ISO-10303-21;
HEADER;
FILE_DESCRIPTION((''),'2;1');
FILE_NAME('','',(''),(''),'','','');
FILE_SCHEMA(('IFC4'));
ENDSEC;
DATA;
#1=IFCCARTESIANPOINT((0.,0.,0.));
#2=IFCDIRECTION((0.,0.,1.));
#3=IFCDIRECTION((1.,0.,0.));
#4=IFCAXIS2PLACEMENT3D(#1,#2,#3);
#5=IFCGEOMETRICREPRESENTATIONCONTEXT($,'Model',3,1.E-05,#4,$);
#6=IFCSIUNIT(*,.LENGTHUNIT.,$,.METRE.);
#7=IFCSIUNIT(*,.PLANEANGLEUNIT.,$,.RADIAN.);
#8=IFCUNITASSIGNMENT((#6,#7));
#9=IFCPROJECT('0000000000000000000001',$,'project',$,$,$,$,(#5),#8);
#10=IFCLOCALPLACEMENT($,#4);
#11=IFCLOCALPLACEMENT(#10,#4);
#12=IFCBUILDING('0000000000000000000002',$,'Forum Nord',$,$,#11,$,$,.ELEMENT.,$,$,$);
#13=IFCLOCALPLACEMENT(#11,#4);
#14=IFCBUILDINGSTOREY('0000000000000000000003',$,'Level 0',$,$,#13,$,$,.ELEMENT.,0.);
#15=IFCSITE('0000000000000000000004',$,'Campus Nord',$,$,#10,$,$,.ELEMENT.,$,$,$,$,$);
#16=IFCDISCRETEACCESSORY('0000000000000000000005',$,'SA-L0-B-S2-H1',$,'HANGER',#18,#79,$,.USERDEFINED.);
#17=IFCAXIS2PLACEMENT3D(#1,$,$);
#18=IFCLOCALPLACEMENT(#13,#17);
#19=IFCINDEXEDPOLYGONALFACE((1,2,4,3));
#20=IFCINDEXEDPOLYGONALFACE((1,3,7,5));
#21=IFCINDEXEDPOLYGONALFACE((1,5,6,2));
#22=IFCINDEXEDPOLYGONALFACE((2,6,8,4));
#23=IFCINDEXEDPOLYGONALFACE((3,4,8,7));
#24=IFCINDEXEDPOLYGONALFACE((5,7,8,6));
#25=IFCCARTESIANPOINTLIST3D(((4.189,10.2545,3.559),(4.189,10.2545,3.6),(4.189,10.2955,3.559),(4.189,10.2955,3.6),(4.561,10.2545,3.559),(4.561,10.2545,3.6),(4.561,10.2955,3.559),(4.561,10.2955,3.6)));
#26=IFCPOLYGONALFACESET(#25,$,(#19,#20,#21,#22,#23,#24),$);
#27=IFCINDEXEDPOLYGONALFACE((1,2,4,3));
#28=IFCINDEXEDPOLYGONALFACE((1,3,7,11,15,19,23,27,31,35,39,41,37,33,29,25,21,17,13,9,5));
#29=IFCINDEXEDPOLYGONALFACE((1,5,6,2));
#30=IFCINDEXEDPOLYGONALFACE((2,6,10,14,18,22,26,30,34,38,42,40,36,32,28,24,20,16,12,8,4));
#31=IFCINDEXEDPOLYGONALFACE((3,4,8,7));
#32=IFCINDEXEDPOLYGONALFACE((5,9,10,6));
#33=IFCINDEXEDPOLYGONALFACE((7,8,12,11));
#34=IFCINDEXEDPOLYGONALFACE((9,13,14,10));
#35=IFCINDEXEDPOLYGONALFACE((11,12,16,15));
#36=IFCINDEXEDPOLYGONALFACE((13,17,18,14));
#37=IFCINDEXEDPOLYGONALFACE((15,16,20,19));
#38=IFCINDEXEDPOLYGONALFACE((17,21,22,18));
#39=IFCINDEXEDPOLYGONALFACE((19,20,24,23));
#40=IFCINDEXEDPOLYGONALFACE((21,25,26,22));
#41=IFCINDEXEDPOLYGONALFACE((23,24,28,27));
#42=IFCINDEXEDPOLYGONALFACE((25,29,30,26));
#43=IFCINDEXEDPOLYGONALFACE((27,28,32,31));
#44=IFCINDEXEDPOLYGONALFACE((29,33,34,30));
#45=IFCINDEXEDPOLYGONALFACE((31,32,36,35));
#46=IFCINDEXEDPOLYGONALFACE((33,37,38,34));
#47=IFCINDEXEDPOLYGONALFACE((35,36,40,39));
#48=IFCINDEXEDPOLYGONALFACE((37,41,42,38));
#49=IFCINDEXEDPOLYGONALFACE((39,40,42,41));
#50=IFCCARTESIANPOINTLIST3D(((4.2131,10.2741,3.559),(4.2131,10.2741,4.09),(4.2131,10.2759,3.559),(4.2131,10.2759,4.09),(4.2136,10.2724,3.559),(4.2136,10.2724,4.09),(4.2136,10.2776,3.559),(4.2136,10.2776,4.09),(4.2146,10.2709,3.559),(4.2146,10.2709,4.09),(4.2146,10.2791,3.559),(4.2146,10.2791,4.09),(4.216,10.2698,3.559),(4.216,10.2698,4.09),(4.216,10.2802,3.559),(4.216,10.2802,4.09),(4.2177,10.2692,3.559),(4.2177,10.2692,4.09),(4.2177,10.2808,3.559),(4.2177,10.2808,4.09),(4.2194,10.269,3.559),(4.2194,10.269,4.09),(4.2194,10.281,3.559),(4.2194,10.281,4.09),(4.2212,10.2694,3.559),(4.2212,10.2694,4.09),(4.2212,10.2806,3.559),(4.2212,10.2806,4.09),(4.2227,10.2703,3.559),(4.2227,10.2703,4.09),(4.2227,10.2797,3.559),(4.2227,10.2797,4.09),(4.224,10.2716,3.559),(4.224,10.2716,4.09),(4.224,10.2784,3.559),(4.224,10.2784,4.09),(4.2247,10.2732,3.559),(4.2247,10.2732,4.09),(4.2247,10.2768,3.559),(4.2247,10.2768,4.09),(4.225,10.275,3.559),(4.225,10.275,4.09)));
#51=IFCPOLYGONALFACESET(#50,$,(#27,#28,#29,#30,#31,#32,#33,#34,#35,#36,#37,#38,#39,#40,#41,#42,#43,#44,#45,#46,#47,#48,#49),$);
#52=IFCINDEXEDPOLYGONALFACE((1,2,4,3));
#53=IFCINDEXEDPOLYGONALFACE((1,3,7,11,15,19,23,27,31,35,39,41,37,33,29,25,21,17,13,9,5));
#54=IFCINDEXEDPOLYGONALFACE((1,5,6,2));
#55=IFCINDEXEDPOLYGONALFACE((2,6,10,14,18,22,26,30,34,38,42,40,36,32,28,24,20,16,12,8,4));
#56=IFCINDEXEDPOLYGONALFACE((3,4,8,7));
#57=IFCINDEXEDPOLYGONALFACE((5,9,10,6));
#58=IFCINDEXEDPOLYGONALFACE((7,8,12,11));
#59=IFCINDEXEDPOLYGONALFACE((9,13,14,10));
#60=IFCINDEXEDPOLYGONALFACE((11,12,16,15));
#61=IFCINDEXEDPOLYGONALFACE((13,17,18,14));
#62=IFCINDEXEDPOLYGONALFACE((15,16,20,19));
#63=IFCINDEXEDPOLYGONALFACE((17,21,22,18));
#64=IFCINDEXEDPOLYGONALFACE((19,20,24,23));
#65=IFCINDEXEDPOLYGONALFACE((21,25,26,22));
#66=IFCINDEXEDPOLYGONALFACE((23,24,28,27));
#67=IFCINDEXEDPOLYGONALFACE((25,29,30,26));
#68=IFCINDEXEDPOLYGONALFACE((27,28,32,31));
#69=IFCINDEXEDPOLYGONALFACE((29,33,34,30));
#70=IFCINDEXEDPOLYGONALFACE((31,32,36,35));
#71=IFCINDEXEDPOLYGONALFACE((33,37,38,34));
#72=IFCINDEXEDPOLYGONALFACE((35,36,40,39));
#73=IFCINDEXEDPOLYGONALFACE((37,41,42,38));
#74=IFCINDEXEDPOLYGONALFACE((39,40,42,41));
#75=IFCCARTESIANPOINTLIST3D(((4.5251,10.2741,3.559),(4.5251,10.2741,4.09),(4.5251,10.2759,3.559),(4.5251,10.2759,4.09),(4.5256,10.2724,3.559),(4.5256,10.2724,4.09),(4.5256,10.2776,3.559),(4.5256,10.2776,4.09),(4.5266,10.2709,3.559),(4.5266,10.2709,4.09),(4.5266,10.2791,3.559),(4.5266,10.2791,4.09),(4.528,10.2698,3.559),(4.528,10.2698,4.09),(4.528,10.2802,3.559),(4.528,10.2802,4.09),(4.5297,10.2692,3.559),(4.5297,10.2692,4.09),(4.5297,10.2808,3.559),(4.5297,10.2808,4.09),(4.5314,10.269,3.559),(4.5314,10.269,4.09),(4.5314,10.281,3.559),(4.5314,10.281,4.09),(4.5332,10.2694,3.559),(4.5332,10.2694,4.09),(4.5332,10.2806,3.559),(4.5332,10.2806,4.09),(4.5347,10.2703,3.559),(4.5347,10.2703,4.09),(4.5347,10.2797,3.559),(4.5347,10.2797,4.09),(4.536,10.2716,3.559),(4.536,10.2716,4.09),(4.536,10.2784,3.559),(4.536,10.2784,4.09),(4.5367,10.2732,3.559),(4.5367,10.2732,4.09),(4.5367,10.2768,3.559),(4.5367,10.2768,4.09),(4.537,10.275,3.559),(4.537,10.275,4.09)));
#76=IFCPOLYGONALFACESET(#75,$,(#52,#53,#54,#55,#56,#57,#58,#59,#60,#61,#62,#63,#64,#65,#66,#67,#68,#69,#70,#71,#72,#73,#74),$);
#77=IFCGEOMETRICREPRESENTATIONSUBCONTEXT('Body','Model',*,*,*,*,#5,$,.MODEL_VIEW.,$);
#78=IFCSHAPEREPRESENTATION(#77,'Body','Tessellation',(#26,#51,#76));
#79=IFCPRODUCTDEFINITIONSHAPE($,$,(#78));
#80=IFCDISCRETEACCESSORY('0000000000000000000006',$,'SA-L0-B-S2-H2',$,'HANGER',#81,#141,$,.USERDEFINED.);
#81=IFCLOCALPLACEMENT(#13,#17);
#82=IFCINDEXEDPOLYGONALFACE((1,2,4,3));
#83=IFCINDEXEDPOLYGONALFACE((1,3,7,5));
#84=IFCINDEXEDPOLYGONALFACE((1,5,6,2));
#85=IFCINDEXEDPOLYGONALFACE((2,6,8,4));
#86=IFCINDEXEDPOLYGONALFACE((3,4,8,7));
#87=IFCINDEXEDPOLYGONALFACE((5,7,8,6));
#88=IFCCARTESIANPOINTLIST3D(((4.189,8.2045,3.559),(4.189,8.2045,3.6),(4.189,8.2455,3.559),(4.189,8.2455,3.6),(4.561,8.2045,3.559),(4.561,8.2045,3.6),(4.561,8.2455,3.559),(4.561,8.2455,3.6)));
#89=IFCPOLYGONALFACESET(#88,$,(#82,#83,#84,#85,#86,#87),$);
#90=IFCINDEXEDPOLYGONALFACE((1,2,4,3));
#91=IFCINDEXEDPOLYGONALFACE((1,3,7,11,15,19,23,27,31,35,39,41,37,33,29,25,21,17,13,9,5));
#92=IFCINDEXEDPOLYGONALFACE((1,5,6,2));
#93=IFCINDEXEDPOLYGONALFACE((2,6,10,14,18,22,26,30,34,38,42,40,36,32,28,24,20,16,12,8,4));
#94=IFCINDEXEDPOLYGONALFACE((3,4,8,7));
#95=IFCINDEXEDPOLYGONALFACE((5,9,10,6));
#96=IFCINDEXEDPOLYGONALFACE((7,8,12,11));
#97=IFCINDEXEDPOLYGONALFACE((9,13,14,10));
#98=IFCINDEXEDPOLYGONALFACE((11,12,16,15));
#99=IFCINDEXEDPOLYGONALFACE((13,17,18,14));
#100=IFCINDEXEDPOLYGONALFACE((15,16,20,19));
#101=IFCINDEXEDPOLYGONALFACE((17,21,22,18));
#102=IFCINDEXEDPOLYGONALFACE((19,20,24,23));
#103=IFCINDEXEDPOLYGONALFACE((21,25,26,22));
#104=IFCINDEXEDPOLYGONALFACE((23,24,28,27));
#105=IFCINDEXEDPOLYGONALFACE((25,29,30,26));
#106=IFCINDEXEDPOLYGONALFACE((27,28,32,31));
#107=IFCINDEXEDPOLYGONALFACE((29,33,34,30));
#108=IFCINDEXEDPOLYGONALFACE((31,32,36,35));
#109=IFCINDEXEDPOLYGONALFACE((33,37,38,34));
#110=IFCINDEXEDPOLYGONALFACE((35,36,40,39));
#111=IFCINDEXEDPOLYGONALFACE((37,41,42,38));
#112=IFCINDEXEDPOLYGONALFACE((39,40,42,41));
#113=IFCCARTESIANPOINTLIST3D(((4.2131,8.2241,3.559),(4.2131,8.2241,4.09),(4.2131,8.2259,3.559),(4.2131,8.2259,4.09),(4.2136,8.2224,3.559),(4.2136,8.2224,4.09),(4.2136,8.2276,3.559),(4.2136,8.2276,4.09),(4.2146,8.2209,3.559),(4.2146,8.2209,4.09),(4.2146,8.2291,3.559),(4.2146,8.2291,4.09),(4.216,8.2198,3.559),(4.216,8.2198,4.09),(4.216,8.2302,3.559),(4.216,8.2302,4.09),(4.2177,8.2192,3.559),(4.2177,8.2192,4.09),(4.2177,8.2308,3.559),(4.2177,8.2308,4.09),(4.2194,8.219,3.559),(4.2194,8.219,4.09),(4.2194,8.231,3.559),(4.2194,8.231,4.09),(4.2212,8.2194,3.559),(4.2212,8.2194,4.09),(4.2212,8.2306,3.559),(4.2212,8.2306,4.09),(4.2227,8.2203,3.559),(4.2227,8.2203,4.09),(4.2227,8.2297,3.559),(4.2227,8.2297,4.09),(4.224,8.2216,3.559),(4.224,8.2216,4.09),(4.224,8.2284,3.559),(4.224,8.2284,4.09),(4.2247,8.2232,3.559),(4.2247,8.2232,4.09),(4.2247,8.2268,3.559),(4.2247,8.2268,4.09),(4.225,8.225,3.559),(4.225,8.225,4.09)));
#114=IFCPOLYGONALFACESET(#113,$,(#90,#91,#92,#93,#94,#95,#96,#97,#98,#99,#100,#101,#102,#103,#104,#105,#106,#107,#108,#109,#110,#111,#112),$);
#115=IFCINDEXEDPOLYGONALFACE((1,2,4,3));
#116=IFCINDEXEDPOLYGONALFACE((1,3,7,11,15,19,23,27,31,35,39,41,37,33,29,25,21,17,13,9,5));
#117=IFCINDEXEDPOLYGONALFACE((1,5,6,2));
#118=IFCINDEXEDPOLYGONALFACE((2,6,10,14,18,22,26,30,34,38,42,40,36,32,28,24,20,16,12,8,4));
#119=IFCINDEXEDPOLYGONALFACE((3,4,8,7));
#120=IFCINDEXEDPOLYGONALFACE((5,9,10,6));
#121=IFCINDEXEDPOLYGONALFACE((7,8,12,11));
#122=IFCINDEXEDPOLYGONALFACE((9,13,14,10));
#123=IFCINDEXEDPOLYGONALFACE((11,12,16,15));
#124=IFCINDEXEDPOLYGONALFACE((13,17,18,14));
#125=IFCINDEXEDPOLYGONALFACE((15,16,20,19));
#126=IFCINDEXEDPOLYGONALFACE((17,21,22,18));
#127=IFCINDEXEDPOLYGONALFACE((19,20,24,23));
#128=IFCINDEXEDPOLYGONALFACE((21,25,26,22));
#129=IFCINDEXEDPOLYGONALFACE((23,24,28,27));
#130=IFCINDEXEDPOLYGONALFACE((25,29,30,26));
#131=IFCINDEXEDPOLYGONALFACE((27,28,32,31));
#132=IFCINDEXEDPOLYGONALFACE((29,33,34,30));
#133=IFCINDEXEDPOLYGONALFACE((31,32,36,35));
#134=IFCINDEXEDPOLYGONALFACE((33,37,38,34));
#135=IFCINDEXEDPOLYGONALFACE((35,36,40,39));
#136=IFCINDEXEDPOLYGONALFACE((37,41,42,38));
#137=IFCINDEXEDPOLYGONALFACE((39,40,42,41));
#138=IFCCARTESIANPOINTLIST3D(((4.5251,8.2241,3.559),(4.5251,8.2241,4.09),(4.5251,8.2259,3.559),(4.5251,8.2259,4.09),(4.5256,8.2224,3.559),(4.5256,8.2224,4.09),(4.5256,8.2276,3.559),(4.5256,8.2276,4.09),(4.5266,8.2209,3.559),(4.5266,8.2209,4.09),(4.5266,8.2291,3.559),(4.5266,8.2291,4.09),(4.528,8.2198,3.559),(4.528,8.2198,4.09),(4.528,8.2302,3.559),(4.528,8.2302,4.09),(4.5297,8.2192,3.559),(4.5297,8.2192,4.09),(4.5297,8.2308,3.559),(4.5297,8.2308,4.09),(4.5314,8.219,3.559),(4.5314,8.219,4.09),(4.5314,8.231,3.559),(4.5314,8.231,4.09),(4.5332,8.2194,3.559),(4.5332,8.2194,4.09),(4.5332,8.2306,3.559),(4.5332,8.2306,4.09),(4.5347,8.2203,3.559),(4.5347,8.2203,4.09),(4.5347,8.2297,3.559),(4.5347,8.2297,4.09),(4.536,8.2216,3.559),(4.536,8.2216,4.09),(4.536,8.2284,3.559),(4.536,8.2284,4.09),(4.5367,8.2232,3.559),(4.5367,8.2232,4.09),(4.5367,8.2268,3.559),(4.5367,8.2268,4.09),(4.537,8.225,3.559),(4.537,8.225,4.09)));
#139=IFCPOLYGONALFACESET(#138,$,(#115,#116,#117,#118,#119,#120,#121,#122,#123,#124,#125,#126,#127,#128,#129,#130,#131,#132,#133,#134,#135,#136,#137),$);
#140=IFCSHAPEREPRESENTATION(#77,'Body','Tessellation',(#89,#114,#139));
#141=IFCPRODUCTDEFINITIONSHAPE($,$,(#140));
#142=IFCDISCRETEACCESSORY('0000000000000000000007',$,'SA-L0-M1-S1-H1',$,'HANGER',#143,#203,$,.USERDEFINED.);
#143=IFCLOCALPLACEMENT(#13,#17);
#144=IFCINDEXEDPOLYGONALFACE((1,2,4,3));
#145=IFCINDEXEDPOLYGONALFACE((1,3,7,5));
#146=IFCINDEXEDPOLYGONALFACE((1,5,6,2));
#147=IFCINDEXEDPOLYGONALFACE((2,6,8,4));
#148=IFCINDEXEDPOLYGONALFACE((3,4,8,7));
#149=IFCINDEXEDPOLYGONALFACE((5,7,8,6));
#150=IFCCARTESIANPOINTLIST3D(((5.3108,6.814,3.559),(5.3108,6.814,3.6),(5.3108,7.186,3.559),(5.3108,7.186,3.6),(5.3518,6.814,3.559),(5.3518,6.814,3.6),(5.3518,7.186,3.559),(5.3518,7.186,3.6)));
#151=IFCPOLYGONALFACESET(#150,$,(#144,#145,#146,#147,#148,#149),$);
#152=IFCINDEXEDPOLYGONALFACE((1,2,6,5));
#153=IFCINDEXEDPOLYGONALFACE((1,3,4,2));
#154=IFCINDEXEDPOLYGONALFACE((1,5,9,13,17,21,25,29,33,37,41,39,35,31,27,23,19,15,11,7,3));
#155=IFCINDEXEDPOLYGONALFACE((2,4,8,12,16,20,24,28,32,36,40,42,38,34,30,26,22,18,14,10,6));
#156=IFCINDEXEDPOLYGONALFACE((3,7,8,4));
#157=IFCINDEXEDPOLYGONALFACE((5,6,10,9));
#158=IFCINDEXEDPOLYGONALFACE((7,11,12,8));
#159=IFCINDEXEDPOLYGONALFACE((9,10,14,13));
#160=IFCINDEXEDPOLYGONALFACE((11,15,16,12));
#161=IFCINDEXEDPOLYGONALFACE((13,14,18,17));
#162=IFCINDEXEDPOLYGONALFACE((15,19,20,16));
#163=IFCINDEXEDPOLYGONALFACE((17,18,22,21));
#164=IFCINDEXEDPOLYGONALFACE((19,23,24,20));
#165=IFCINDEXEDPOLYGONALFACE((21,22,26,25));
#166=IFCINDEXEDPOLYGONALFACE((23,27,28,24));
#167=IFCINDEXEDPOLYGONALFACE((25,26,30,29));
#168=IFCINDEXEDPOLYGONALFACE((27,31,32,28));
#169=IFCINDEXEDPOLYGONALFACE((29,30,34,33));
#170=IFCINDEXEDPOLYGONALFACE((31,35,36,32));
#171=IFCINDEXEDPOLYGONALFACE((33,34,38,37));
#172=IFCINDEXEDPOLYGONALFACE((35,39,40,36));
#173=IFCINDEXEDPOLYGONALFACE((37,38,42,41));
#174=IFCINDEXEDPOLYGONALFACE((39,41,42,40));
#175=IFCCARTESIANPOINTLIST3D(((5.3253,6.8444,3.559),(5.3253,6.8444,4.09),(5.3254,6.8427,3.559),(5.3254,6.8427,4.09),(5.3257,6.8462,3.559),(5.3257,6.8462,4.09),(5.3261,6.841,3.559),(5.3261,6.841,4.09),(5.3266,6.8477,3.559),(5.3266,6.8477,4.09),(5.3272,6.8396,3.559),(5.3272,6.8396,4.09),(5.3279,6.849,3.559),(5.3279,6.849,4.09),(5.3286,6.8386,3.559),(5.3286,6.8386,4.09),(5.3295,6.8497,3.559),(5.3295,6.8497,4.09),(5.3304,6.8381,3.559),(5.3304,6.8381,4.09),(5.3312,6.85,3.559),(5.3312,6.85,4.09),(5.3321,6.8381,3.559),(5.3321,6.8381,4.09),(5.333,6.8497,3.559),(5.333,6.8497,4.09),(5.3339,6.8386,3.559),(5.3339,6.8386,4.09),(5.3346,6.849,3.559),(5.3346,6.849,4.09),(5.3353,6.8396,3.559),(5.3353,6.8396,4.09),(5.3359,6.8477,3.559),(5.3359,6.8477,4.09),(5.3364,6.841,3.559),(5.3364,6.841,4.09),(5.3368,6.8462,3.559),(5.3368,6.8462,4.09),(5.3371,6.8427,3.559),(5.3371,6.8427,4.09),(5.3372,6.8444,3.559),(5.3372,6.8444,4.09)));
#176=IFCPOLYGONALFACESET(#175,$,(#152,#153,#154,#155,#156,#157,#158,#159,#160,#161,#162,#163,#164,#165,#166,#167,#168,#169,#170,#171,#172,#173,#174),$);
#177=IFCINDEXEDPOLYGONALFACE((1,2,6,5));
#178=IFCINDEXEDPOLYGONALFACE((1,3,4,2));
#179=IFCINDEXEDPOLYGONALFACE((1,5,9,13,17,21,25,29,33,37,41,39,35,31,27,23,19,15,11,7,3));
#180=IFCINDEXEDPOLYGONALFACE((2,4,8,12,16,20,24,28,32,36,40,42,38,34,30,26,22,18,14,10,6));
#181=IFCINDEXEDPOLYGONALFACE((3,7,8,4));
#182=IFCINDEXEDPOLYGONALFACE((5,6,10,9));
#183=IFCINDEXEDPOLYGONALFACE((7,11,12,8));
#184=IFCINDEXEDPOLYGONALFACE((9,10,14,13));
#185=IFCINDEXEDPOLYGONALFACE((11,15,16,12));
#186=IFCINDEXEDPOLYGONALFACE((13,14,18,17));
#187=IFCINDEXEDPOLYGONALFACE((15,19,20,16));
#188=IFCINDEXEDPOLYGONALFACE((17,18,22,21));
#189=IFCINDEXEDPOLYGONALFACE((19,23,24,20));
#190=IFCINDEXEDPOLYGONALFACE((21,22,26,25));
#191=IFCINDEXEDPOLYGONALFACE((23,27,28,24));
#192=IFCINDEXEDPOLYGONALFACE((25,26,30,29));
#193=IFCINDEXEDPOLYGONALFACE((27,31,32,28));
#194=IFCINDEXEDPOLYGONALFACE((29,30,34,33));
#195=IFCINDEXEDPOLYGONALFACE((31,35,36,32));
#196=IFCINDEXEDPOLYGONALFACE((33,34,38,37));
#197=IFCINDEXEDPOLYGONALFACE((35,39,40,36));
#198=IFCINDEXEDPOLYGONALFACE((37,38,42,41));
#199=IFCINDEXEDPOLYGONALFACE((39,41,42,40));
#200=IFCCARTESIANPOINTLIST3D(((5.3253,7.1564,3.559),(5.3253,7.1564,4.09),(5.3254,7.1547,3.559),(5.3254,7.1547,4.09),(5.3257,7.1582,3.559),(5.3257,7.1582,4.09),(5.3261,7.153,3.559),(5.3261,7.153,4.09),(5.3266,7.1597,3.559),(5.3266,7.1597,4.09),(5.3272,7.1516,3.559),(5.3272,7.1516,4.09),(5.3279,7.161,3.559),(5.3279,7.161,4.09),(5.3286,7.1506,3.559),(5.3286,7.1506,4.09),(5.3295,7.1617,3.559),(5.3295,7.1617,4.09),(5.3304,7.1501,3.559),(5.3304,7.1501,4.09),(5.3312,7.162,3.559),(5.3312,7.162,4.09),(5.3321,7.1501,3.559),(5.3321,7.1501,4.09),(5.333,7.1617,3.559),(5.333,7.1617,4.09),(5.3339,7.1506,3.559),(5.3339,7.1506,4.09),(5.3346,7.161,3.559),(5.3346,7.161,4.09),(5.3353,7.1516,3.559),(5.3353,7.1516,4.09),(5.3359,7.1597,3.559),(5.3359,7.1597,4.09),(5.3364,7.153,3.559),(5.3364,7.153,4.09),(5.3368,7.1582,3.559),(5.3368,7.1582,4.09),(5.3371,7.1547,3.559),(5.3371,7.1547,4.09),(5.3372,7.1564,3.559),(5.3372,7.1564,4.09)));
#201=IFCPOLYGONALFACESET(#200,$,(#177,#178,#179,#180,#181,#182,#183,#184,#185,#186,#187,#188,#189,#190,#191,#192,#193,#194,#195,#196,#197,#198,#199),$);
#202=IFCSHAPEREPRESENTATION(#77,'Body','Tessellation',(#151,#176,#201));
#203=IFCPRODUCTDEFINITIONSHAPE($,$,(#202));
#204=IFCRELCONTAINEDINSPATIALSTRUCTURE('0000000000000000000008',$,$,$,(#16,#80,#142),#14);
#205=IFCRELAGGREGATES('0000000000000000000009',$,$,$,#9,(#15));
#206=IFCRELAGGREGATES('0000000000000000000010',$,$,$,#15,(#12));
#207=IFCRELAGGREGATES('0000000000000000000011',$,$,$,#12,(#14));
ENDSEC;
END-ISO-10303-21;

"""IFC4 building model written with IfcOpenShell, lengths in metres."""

from ifc_helpers import new_model, si_unit, frame, frame_2d, origin_with_axes, origin_2d_with_axis, place, context, subcontext, project, spatial, rectangle, circle, extrude, element, save


model = new_model("IFC4")

# Units and contexts
model_context = context("Model", 3, precision=1e-05, world=origin_with_axes())
body_context = subcontext(model_context, "Body", "Model", "MODEL_VIEW")
ifc_project = project(units=[si_unit("LENGTHUNIT", "METRE"), si_unit("PLANEANGLEUNIT", "RADIAN")], contexts=[model_context])

# Site, building, storey
site_placement = place(None, origin_with_axes())
site = spatial("IfcSite", under=ifc_project, at=site_placement, Name="Campus Nord", CompositionType="ELEMENT")
building_placement = place(site_placement, origin_with_axes())
building = spatial("IfcBuilding", under=site, at=building_placement, Name="Forum Nord", CompositionType="ELEMENT")
storey_placement = place(building_placement, origin_with_axes())
storey = spatial("IfcBuildingStorey", under=building, at=storey_placement, Name="Level 0", CompositionType="ELEMENT", Elevation=0.0)

# Discrete accessories
for number, where, z_axis, x_axis, name in (
    (1, (4.375, 10.275, 3.6), (0.0, 0.0, 1.0), (1.0, 0.0, 0.0), "SA-L0-B-S2-H1"),
    (2, (4.375, 8.225, 3.6), (0.0, 0.0, 1.0), (1.0, 0.0, 0.0), "SA-L0-B-S2-H2"),
    (3, (5.3312, 7.0, 3.6), (0.0, 0.0, 1.0), (0.0, 1.0, 0.0), "SA-L0-M1-S1-H1"),
):
    element("IfcDiscreteAccessory", number, at=place(storey_placement, frame(where, z_axis=z_axis, x_axis=x_axis)), inside=storey, Name=name, ObjectType="HANGER", PredefinedType="USERDEFINED", context=body_context, shape_type="SweptSolid", body=[
        extrude(rectangle(XDim=0.372, YDim=0.041, at=origin_2d_with_axis()), frame((0.0, 0.0, -0.041), z_axis=(0.0, 0.0, 1.0), x_axis=(1.0, 0.0, 0.0)), (0.0, 0.0, 1.0), 0.041),
        extrude(circle(Radius=0.006, at=frame_2d((-0.156, 0.0), x_axis=(1.0, 0.0))), frame((0.0, 0.0, -0.041), z_axis=(0.0, 0.0, 1.0), x_axis=(1.0, 0.0, 0.0)), (0.0, 0.0, 1.0), 0.531),
        extrude(circle(Radius=0.006, at=frame_2d((0.156, 0.0), x_axis=(1.0, 0.0))), frame((0.0, 0.0, -0.041), z_axis=(0.0, 0.0, 1.0), x_axis=(1.0, 0.0, 0.0)), (0.0, 0.0, 1.0), 0.531),
    ])

save(model, "model.ifc")
